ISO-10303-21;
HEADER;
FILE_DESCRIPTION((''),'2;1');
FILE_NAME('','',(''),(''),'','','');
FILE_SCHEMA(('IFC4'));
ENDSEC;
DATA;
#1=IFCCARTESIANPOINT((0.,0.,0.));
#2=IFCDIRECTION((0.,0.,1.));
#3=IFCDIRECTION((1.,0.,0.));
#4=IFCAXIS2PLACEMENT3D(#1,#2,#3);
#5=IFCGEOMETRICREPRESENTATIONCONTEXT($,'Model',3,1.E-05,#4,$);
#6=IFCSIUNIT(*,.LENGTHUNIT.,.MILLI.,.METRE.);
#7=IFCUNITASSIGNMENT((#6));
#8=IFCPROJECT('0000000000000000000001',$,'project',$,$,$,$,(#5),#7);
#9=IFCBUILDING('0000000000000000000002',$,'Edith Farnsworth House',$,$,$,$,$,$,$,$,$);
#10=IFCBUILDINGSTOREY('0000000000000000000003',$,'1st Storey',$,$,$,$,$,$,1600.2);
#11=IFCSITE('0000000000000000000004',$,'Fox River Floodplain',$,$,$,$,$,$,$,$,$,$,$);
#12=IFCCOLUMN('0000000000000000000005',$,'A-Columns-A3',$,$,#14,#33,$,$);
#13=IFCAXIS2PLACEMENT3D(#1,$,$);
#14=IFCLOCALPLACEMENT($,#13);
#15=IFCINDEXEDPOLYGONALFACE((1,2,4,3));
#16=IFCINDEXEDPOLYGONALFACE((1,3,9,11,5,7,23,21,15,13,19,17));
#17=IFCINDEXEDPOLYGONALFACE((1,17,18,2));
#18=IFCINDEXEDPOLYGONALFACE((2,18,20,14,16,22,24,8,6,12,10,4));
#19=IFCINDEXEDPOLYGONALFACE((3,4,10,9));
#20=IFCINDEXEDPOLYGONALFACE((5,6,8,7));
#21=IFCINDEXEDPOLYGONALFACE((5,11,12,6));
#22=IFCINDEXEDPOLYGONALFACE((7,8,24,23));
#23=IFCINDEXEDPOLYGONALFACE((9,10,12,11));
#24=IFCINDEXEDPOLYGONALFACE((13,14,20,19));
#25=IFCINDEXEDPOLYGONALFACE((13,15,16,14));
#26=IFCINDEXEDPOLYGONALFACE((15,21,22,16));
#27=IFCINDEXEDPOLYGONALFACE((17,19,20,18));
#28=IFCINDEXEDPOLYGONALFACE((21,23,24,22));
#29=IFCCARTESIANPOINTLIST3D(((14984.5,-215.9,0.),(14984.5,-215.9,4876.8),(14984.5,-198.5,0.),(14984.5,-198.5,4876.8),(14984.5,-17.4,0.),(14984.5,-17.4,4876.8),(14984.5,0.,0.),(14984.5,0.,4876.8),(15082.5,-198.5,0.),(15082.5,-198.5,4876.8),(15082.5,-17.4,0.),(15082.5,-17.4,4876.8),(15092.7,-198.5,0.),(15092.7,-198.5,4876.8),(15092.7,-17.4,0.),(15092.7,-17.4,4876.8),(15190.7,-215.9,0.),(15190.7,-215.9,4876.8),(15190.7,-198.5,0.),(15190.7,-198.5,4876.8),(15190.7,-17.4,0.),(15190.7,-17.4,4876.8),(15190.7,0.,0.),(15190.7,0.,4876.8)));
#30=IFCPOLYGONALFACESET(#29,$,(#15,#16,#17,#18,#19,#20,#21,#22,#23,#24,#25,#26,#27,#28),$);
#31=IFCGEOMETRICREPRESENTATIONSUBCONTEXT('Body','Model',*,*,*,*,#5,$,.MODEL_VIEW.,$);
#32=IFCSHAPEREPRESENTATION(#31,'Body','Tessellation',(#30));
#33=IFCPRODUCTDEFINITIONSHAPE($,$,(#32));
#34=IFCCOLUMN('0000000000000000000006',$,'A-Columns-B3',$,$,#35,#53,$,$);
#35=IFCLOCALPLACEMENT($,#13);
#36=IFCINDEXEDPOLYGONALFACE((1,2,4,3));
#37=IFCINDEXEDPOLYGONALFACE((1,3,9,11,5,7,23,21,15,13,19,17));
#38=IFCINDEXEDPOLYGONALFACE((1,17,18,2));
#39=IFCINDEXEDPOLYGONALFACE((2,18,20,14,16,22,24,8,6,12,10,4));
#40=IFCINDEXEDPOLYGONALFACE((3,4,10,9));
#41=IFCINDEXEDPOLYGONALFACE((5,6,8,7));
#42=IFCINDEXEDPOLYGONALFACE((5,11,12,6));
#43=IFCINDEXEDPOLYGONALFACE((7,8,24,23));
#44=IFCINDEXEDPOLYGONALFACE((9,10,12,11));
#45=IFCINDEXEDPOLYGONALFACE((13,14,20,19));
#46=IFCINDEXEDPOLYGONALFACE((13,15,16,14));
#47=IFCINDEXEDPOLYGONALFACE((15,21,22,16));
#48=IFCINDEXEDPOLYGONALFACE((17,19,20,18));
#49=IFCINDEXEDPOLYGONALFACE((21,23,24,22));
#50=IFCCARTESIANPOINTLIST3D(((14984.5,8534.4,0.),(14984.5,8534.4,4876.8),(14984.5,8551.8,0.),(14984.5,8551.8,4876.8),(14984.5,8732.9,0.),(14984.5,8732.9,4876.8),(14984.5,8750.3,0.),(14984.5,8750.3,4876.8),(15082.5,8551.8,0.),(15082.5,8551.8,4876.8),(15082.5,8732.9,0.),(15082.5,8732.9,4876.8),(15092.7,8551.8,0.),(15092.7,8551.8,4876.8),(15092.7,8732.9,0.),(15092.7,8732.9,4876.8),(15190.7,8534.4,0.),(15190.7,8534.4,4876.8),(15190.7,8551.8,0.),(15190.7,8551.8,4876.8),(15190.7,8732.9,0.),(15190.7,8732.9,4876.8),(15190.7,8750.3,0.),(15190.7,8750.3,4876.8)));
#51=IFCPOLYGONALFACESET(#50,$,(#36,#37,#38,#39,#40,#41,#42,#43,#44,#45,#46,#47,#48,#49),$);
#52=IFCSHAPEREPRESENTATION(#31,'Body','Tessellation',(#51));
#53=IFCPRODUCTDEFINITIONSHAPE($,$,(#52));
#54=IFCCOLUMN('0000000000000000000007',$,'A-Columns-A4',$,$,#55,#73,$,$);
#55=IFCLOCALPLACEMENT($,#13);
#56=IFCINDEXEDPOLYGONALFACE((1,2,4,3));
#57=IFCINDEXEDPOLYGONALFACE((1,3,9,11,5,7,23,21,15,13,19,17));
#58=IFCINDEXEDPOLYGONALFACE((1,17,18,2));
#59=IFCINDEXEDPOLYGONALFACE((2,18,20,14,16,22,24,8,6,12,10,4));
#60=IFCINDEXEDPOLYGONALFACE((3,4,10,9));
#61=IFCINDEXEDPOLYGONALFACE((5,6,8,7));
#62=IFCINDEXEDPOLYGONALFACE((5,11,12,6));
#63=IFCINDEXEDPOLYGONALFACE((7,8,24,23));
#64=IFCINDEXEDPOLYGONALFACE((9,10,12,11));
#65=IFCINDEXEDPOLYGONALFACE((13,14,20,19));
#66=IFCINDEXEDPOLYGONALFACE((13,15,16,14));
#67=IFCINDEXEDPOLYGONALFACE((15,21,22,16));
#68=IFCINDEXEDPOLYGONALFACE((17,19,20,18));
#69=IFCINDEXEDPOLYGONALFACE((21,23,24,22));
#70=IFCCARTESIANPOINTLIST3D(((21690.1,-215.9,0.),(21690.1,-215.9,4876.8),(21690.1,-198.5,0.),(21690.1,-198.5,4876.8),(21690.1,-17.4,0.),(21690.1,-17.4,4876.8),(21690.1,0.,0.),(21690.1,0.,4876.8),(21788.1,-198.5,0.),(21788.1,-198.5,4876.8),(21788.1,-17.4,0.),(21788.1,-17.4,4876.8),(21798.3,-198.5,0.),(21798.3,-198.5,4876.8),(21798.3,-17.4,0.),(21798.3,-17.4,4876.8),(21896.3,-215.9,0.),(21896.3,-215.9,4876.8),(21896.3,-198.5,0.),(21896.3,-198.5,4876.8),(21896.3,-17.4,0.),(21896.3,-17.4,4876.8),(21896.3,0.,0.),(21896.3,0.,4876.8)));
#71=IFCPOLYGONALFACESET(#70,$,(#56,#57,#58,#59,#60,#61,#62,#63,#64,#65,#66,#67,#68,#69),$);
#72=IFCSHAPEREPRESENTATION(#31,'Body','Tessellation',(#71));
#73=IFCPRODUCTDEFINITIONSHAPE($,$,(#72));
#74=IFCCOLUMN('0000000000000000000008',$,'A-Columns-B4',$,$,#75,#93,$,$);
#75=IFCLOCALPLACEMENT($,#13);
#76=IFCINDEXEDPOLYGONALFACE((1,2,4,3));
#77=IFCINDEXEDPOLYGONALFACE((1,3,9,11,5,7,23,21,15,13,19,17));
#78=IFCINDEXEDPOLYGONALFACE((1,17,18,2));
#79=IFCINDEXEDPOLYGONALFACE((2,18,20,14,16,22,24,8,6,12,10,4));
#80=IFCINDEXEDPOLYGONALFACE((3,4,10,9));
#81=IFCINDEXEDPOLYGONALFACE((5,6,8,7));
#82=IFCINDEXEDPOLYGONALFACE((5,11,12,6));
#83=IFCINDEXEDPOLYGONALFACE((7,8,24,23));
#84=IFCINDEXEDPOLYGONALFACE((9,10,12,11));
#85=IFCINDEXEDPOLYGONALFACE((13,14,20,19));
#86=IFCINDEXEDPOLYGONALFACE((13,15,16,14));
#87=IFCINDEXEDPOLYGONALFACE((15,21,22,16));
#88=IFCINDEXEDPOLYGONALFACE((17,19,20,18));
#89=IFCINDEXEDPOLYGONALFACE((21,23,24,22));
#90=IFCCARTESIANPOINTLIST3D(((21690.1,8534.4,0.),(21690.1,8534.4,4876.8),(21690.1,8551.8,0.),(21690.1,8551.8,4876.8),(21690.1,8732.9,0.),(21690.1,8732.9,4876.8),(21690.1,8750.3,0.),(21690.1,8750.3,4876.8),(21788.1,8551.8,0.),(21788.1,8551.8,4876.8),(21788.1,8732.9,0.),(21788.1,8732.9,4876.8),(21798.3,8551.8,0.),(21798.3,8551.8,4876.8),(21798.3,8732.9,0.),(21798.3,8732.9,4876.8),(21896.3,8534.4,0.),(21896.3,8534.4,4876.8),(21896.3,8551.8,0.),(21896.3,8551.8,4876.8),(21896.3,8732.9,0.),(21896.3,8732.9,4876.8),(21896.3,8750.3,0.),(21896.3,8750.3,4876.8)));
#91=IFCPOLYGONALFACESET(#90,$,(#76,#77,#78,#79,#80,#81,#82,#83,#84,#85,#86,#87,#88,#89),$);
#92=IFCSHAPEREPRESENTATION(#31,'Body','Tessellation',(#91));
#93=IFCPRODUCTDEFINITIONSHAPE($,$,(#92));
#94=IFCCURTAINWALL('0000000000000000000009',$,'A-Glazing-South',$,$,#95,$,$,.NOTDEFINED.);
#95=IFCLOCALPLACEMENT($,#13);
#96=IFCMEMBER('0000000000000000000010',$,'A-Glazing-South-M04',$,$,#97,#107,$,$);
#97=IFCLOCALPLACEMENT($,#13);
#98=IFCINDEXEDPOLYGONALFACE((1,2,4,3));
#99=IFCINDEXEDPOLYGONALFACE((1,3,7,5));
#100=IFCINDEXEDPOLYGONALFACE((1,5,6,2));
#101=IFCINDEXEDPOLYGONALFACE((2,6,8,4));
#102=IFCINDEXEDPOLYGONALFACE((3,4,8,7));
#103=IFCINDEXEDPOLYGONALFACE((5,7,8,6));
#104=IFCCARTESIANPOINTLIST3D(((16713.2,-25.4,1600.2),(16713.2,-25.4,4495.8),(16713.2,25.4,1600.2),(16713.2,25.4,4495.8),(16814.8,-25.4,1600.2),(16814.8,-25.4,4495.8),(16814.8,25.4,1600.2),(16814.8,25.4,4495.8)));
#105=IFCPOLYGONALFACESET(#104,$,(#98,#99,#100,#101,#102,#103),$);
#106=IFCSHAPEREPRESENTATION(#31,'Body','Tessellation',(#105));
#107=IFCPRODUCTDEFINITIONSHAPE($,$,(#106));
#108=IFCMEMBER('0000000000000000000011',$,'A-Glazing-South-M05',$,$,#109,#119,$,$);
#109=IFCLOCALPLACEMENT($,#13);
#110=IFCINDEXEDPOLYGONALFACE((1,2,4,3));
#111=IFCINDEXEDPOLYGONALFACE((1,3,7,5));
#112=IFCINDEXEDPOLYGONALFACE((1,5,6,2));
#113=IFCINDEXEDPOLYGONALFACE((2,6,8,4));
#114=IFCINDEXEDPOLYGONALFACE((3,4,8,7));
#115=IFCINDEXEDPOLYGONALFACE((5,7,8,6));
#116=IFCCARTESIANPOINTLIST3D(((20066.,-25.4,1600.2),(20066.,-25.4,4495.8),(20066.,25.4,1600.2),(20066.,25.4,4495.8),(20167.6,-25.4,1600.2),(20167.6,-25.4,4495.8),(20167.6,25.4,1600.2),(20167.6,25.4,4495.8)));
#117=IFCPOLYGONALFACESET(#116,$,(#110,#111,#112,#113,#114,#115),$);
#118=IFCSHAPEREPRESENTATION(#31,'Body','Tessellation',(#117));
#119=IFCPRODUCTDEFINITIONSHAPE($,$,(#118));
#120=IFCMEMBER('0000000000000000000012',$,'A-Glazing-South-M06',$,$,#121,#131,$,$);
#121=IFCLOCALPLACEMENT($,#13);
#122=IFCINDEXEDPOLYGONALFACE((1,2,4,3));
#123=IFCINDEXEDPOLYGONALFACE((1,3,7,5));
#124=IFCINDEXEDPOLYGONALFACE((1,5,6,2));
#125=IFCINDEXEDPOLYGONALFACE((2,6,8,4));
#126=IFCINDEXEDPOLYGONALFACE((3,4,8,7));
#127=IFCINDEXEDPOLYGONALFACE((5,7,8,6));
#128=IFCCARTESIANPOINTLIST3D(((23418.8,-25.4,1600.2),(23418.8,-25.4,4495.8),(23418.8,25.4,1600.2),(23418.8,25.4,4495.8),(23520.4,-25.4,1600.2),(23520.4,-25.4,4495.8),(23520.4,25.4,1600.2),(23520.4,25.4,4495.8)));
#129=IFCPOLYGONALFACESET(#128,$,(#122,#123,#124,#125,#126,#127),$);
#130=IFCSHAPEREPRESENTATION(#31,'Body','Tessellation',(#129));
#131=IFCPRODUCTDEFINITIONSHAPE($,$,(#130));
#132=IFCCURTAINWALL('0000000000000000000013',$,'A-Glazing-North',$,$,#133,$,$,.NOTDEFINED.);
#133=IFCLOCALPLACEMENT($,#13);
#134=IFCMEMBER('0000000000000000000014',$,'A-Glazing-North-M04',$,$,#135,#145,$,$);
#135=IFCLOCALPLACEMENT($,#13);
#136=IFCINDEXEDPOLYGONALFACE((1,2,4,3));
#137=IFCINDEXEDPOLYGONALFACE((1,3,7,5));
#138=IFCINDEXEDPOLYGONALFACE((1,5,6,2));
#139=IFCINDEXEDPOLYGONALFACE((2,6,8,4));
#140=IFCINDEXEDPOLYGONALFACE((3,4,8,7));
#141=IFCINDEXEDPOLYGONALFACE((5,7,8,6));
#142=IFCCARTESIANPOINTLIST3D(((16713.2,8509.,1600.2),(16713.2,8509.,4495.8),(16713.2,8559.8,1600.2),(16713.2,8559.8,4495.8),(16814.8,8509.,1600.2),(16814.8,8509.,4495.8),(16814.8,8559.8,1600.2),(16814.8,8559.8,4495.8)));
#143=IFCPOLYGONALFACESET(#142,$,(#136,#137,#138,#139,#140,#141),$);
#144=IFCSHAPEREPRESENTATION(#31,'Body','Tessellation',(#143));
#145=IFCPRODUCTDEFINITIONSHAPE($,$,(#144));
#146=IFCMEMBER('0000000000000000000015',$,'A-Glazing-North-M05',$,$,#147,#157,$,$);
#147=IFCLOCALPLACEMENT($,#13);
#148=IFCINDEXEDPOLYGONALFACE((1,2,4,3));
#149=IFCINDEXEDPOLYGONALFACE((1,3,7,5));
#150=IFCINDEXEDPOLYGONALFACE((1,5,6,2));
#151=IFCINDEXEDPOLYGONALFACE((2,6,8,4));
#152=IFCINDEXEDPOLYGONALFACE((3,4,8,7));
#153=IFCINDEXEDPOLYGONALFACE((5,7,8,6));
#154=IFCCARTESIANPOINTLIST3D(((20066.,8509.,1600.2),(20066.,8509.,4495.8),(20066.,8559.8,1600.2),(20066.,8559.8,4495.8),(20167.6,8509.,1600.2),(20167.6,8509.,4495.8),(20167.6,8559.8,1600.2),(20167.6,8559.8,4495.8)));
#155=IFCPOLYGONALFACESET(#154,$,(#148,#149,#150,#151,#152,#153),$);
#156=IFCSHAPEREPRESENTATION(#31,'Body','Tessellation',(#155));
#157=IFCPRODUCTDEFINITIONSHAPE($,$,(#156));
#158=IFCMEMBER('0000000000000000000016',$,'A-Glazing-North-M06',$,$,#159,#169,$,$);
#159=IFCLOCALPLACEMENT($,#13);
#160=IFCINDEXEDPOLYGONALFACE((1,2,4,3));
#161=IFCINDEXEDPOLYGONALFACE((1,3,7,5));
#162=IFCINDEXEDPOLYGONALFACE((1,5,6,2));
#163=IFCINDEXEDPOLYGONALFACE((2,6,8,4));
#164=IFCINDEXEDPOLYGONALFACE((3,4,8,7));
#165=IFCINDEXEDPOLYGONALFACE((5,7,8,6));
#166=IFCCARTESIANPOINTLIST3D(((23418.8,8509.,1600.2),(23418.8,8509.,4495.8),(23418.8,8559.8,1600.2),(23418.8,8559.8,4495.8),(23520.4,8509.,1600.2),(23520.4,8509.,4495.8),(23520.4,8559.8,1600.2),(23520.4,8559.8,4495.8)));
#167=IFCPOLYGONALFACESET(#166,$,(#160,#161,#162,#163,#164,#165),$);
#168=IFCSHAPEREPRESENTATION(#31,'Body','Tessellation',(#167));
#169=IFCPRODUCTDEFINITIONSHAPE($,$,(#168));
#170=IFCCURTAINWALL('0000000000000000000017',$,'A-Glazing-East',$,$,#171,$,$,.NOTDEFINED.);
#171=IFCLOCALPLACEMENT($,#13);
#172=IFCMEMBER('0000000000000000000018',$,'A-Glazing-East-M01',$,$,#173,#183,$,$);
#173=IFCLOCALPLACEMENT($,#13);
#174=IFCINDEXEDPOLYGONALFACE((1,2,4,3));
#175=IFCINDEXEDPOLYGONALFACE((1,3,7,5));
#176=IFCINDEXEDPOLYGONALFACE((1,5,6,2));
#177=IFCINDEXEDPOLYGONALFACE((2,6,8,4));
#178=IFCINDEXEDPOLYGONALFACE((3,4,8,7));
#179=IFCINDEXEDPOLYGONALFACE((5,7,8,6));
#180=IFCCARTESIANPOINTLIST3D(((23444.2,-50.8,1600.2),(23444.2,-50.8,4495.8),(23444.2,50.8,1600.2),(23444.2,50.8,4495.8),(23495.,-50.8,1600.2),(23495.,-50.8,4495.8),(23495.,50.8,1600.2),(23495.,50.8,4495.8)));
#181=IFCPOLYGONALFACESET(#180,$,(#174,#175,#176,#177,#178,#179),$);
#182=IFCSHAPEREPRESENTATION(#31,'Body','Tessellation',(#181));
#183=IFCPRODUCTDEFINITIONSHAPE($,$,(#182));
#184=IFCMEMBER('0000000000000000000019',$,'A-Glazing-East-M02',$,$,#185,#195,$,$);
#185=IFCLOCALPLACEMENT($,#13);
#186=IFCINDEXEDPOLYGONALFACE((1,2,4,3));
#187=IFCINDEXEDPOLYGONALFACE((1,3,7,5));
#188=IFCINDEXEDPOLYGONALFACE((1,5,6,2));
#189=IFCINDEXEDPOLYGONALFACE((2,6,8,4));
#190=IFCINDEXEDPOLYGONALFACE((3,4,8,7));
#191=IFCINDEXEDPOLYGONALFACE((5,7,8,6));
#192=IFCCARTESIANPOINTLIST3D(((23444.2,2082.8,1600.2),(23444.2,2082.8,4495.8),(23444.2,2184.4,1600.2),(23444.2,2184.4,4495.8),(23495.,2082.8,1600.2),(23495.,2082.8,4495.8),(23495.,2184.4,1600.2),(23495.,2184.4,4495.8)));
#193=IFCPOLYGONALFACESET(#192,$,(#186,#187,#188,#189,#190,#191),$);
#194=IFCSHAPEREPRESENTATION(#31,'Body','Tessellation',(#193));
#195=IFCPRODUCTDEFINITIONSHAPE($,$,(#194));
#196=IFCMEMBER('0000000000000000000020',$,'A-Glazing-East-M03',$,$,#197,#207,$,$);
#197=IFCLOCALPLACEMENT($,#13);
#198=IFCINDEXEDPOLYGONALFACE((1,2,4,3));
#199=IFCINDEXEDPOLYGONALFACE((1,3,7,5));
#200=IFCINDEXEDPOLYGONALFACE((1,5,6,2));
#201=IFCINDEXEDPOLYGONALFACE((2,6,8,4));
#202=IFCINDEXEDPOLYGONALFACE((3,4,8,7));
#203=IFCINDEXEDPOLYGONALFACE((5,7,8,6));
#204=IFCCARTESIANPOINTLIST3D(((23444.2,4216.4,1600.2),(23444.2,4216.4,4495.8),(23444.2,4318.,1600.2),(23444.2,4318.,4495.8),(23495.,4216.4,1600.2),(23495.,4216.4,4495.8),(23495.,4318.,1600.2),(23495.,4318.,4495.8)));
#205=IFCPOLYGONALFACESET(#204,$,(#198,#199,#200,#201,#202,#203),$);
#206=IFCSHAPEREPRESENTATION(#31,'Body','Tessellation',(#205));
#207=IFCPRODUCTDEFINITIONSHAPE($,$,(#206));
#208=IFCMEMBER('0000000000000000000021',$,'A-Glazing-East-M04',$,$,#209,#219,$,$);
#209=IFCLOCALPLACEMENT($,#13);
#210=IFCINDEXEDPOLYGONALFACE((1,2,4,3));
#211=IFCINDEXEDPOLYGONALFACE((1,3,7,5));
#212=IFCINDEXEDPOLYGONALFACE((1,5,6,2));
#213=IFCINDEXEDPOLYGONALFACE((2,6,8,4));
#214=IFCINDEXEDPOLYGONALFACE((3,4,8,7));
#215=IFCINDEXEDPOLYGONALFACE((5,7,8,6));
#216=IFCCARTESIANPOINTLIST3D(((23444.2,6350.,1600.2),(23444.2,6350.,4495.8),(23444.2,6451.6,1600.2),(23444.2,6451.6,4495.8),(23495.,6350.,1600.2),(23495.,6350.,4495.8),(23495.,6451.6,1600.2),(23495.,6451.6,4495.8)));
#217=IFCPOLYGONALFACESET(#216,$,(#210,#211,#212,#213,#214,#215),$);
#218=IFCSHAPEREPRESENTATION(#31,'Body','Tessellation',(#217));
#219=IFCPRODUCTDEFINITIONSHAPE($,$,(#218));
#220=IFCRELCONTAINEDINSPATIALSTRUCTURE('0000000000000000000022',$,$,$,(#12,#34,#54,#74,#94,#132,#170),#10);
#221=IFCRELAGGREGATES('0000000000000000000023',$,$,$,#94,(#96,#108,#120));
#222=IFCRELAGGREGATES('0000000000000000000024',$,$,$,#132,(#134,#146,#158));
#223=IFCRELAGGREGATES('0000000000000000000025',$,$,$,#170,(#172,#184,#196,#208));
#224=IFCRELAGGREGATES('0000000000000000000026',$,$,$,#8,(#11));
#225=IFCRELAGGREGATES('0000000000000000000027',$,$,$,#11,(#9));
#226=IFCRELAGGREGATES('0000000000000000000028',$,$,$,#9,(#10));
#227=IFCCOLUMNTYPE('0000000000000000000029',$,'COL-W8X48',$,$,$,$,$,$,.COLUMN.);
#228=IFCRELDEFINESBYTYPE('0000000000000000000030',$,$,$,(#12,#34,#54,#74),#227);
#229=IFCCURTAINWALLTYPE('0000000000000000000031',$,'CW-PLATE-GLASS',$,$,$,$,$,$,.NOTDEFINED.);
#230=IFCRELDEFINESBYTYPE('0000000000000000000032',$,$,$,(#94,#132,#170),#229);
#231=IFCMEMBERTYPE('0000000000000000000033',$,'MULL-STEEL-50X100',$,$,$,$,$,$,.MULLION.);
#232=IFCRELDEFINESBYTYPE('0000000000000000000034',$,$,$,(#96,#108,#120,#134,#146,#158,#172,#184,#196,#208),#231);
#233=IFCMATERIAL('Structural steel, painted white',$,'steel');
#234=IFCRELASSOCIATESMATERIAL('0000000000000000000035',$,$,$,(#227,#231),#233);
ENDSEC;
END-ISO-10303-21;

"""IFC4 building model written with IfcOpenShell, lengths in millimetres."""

from ifc_helpers import new_model, si_unit, frame, origin, origin_with_axes, place, context, subcontext, project, spatial, rectangle, i_section, extrude, material, type_object, element, aggregate, save


model = new_model("IFC4")

# Units and contexts
model_context = context("Model", 3, precision=1e-05, world=origin_with_axes())
body_context = subcontext(model_context, "Body", "Model", "MODEL_VIEW")
ifc_project = project(units=[si_unit("LENGTHUNIT", "METRE", prefix="MILLI")], contexts=[model_context])

# Site, building, storey
site = spatial("IfcSite", under=ifc_project, Name="Fox River Floodplain")
building = spatial("IfcBuilding", under=site, Name="Edith Farnsworth House")
storey = spatial("IfcBuildingStorey", under=building, Name="1st Storey", Elevation=1600.2)

# Columns
ifc_material_1 = material(Name="Structural steel, painted white", Category="steel")
column_type = type_object("IfcColumnType", Name="COL-W8X48", PredefinedType="COLUMN", material=ifc_material_1)
for number, where, z_axis, x_axis, name in (
    (1, (15087.6, -108.0, 0.0), (0.0, 0.0, 1.0), (1.0, 0.0, 0.0), "A-Columns-A3"),
    (2, (15087.6, 8642.4, 0.0), (0.0, 0.0, 1.0), (1.0, 0.0, 0.0), "A-Columns-B3"),
    (3, (21793.2, -108.0, 0.0), (0.0, 0.0, 1.0), (1.0, 0.0, 0.0), "A-Columns-A4"),
    (4, (21793.2, 8642.4, 0.0), (0.0, 0.0, 1.0), (1.0, 0.0, 0.0), "A-Columns-B4"),
):
    element("IfcColumn", number, at=place(None, frame(where, z_axis=z_axis, x_axis=x_axis)), inside=storey, type_object=column_type, Name=name, context=body_context, shape_type="SweptSolid", body=[
        extrude(i_section(OverallWidth=206.2, OverallDepth=215.9, WebThickness=10.2, FlangeThickness=17.4), origin(), (0.0, 0.0, 1.0), 4876.8),
    ])

# Curtain walls, members
curtain_wall_type = type_object("IfcCurtainWallType", Name="CW-PLATE-GLASS", PredefinedType="NOTDEFINED")
curtain_wall_1 = element("IfcCurtainWall", 5, inside=storey, type_object=curtain_wall_type, Name="A-Glazing-South", PredefinedType="NOTDEFINED")
member_type = type_object("IfcMemberType", Name="MULL-STEEL-50X100", PredefinedType="MULLION", material=ifc_material_1)
member_1_placement = place(None, frame((16764.0, 0.0, 1600.2), z_axis=(0.0, 0.0, 1.0), x_axis=(0.0, 1.0, 0.0)))
member_1 = element("IfcMember", 6, at=member_1_placement, type_object=member_type, Name="A-Glazing-South-M04", context=body_context, shape_type="SweptSolid", body=[
    extrude(rectangle(XDim=50.8, YDim=101.6), origin(), (0.0, 0.0, 1.0), 2895.6),
])
member_2_placement = place(None, frame((20116.8, 0.0, 1600.2), z_axis=(0.0, 0.0, 1.0), x_axis=(0.0, 1.0, 0.0)))
member_2 = element("IfcMember", 7, at=member_2_placement, type_object=member_type, Name="A-Glazing-South-M05", context=body_context, shape_type="SweptSolid", body=[
    extrude(rectangle(XDim=50.8, YDim=101.6), origin(), (0.0, 0.0, 1.0), 2895.6),
])
member_3_placement = place(None, frame((23469.6, 0.0, 1600.2), z_axis=(0.0, 0.0, 1.0), x_axis=(0.0, 1.0, 0.0)))
member_3 = element("IfcMember", 8, at=member_3_placement, type_object=member_type, Name="A-Glazing-South-M06", context=body_context, shape_type="SweptSolid", body=[
    extrude(rectangle(XDim=50.8, YDim=101.6), origin(), (0.0, 0.0, 1.0), 2895.6),
])
curtain_wall_2 = element("IfcCurtainWall", 9, inside=storey, type_object=curtain_wall_type, Name="A-Glazing-North", PredefinedType="NOTDEFINED")
member_4_placement = place(None, frame((16764.0, 8534.4, 1600.2), z_axis=(0.0, 0.0, 1.0), x_axis=(0.0, 1.0, 0.0)))
member_4 = element("IfcMember", 10, at=member_4_placement, type_object=member_type, Name="A-Glazing-North-M04", context=body_context, shape_type="SweptSolid", body=[
    extrude(rectangle(XDim=50.8, YDim=101.6), origin(), (0.0, 0.0, 1.0), 2895.6),
])
member_5_placement = place(None, frame((20116.8, 8534.4, 1600.2), z_axis=(0.0, 0.0, 1.0), x_axis=(0.0, 1.0, 0.0)))
member_5 = element("IfcMember", 11, at=member_5_placement, type_object=member_type, Name="A-Glazing-North-M05", context=body_context, shape_type="SweptSolid", body=[
    extrude(rectangle(XDim=50.8, YDim=101.6), origin(), (0.0, 0.0, 1.0), 2895.6),
])
member_6_placement = place(None, frame((23469.6, 8534.4, 1600.2), z_axis=(0.0, 0.0, 1.0), x_axis=(0.0, 1.0, 0.0)))
member_6 = element("IfcMember", 12, at=member_6_placement, type_object=member_type, Name="A-Glazing-North-M06", context=body_context, shape_type="SweptSolid", body=[
    extrude(rectangle(XDim=50.8, YDim=101.6), origin(), (0.0, 0.0, 1.0), 2895.6),
])
curtain_wall_3 = element("IfcCurtainWall", 13, inside=storey, type_object=curtain_wall_type, Name="A-Glazing-East", PredefinedType="NOTDEFINED")
member_7_placement = place(None, frame((23469.6, 0.0, 1600.2), z_axis=(0.0, 0.0, 1.0), x_axis=(1.0, 0.0, 0.0)))
member_7 = element("IfcMember", 14, at=member_7_placement, type_object=member_type, Name="A-Glazing-East-M01", context=body_context, shape_type="SweptSolid", body=[
    extrude(rectangle(XDim=50.8, YDim=101.6), origin(), (0.0, 0.0, 1.0), 2895.6),
])
member_8_placement = place(None, frame((23469.6, 2133.6, 1600.2), z_axis=(0.0, 0.0, 1.0), x_axis=(1.0, 0.0, 0.0)))
member_8 = element("IfcMember", 15, at=member_8_placement, type_object=member_type, Name="A-Glazing-East-M02", context=body_context, shape_type="SweptSolid", body=[
    extrude(rectangle(XDim=50.8, YDim=101.6), origin(), (0.0, 0.0, 1.0), 2895.6),
])
member_9_placement = place(None, frame((23469.6, 4267.2, 1600.2), z_axis=(0.0, 0.0, 1.0), x_axis=(1.0, 0.0, 0.0)))
member_9 = element("IfcMember", 16, at=member_9_placement, type_object=member_type, Name="A-Glazing-East-M03", context=body_context, shape_type="SweptSolid", body=[
    extrude(rectangle(XDim=50.8, YDim=101.6), origin(), (0.0, 0.0, 1.0), 2895.6),
])
member_10_placement = place(None, frame((23469.6, 6400.8, 1600.2), z_axis=(0.0, 0.0, 1.0), x_axis=(1.0, 0.0, 0.0)))
member_10 = element("IfcMember", 17, at=member_10_placement, type_object=member_type, Name="A-Glazing-East-M04", context=body_context, shape_type="SweptSolid", body=[
    extrude(rectangle(XDim=50.8, YDim=101.6), origin(), (0.0, 0.0, 1.0), 2895.6),
])

aggregate(curtain_wall_1, [member_1, member_2, member_3])
aggregate(curtain_wall_2, [member_4, member_5, member_6])
aggregate(curtain_wall_3, [member_7, member_8, member_9, member_10])

save(model, "model.ifc")
